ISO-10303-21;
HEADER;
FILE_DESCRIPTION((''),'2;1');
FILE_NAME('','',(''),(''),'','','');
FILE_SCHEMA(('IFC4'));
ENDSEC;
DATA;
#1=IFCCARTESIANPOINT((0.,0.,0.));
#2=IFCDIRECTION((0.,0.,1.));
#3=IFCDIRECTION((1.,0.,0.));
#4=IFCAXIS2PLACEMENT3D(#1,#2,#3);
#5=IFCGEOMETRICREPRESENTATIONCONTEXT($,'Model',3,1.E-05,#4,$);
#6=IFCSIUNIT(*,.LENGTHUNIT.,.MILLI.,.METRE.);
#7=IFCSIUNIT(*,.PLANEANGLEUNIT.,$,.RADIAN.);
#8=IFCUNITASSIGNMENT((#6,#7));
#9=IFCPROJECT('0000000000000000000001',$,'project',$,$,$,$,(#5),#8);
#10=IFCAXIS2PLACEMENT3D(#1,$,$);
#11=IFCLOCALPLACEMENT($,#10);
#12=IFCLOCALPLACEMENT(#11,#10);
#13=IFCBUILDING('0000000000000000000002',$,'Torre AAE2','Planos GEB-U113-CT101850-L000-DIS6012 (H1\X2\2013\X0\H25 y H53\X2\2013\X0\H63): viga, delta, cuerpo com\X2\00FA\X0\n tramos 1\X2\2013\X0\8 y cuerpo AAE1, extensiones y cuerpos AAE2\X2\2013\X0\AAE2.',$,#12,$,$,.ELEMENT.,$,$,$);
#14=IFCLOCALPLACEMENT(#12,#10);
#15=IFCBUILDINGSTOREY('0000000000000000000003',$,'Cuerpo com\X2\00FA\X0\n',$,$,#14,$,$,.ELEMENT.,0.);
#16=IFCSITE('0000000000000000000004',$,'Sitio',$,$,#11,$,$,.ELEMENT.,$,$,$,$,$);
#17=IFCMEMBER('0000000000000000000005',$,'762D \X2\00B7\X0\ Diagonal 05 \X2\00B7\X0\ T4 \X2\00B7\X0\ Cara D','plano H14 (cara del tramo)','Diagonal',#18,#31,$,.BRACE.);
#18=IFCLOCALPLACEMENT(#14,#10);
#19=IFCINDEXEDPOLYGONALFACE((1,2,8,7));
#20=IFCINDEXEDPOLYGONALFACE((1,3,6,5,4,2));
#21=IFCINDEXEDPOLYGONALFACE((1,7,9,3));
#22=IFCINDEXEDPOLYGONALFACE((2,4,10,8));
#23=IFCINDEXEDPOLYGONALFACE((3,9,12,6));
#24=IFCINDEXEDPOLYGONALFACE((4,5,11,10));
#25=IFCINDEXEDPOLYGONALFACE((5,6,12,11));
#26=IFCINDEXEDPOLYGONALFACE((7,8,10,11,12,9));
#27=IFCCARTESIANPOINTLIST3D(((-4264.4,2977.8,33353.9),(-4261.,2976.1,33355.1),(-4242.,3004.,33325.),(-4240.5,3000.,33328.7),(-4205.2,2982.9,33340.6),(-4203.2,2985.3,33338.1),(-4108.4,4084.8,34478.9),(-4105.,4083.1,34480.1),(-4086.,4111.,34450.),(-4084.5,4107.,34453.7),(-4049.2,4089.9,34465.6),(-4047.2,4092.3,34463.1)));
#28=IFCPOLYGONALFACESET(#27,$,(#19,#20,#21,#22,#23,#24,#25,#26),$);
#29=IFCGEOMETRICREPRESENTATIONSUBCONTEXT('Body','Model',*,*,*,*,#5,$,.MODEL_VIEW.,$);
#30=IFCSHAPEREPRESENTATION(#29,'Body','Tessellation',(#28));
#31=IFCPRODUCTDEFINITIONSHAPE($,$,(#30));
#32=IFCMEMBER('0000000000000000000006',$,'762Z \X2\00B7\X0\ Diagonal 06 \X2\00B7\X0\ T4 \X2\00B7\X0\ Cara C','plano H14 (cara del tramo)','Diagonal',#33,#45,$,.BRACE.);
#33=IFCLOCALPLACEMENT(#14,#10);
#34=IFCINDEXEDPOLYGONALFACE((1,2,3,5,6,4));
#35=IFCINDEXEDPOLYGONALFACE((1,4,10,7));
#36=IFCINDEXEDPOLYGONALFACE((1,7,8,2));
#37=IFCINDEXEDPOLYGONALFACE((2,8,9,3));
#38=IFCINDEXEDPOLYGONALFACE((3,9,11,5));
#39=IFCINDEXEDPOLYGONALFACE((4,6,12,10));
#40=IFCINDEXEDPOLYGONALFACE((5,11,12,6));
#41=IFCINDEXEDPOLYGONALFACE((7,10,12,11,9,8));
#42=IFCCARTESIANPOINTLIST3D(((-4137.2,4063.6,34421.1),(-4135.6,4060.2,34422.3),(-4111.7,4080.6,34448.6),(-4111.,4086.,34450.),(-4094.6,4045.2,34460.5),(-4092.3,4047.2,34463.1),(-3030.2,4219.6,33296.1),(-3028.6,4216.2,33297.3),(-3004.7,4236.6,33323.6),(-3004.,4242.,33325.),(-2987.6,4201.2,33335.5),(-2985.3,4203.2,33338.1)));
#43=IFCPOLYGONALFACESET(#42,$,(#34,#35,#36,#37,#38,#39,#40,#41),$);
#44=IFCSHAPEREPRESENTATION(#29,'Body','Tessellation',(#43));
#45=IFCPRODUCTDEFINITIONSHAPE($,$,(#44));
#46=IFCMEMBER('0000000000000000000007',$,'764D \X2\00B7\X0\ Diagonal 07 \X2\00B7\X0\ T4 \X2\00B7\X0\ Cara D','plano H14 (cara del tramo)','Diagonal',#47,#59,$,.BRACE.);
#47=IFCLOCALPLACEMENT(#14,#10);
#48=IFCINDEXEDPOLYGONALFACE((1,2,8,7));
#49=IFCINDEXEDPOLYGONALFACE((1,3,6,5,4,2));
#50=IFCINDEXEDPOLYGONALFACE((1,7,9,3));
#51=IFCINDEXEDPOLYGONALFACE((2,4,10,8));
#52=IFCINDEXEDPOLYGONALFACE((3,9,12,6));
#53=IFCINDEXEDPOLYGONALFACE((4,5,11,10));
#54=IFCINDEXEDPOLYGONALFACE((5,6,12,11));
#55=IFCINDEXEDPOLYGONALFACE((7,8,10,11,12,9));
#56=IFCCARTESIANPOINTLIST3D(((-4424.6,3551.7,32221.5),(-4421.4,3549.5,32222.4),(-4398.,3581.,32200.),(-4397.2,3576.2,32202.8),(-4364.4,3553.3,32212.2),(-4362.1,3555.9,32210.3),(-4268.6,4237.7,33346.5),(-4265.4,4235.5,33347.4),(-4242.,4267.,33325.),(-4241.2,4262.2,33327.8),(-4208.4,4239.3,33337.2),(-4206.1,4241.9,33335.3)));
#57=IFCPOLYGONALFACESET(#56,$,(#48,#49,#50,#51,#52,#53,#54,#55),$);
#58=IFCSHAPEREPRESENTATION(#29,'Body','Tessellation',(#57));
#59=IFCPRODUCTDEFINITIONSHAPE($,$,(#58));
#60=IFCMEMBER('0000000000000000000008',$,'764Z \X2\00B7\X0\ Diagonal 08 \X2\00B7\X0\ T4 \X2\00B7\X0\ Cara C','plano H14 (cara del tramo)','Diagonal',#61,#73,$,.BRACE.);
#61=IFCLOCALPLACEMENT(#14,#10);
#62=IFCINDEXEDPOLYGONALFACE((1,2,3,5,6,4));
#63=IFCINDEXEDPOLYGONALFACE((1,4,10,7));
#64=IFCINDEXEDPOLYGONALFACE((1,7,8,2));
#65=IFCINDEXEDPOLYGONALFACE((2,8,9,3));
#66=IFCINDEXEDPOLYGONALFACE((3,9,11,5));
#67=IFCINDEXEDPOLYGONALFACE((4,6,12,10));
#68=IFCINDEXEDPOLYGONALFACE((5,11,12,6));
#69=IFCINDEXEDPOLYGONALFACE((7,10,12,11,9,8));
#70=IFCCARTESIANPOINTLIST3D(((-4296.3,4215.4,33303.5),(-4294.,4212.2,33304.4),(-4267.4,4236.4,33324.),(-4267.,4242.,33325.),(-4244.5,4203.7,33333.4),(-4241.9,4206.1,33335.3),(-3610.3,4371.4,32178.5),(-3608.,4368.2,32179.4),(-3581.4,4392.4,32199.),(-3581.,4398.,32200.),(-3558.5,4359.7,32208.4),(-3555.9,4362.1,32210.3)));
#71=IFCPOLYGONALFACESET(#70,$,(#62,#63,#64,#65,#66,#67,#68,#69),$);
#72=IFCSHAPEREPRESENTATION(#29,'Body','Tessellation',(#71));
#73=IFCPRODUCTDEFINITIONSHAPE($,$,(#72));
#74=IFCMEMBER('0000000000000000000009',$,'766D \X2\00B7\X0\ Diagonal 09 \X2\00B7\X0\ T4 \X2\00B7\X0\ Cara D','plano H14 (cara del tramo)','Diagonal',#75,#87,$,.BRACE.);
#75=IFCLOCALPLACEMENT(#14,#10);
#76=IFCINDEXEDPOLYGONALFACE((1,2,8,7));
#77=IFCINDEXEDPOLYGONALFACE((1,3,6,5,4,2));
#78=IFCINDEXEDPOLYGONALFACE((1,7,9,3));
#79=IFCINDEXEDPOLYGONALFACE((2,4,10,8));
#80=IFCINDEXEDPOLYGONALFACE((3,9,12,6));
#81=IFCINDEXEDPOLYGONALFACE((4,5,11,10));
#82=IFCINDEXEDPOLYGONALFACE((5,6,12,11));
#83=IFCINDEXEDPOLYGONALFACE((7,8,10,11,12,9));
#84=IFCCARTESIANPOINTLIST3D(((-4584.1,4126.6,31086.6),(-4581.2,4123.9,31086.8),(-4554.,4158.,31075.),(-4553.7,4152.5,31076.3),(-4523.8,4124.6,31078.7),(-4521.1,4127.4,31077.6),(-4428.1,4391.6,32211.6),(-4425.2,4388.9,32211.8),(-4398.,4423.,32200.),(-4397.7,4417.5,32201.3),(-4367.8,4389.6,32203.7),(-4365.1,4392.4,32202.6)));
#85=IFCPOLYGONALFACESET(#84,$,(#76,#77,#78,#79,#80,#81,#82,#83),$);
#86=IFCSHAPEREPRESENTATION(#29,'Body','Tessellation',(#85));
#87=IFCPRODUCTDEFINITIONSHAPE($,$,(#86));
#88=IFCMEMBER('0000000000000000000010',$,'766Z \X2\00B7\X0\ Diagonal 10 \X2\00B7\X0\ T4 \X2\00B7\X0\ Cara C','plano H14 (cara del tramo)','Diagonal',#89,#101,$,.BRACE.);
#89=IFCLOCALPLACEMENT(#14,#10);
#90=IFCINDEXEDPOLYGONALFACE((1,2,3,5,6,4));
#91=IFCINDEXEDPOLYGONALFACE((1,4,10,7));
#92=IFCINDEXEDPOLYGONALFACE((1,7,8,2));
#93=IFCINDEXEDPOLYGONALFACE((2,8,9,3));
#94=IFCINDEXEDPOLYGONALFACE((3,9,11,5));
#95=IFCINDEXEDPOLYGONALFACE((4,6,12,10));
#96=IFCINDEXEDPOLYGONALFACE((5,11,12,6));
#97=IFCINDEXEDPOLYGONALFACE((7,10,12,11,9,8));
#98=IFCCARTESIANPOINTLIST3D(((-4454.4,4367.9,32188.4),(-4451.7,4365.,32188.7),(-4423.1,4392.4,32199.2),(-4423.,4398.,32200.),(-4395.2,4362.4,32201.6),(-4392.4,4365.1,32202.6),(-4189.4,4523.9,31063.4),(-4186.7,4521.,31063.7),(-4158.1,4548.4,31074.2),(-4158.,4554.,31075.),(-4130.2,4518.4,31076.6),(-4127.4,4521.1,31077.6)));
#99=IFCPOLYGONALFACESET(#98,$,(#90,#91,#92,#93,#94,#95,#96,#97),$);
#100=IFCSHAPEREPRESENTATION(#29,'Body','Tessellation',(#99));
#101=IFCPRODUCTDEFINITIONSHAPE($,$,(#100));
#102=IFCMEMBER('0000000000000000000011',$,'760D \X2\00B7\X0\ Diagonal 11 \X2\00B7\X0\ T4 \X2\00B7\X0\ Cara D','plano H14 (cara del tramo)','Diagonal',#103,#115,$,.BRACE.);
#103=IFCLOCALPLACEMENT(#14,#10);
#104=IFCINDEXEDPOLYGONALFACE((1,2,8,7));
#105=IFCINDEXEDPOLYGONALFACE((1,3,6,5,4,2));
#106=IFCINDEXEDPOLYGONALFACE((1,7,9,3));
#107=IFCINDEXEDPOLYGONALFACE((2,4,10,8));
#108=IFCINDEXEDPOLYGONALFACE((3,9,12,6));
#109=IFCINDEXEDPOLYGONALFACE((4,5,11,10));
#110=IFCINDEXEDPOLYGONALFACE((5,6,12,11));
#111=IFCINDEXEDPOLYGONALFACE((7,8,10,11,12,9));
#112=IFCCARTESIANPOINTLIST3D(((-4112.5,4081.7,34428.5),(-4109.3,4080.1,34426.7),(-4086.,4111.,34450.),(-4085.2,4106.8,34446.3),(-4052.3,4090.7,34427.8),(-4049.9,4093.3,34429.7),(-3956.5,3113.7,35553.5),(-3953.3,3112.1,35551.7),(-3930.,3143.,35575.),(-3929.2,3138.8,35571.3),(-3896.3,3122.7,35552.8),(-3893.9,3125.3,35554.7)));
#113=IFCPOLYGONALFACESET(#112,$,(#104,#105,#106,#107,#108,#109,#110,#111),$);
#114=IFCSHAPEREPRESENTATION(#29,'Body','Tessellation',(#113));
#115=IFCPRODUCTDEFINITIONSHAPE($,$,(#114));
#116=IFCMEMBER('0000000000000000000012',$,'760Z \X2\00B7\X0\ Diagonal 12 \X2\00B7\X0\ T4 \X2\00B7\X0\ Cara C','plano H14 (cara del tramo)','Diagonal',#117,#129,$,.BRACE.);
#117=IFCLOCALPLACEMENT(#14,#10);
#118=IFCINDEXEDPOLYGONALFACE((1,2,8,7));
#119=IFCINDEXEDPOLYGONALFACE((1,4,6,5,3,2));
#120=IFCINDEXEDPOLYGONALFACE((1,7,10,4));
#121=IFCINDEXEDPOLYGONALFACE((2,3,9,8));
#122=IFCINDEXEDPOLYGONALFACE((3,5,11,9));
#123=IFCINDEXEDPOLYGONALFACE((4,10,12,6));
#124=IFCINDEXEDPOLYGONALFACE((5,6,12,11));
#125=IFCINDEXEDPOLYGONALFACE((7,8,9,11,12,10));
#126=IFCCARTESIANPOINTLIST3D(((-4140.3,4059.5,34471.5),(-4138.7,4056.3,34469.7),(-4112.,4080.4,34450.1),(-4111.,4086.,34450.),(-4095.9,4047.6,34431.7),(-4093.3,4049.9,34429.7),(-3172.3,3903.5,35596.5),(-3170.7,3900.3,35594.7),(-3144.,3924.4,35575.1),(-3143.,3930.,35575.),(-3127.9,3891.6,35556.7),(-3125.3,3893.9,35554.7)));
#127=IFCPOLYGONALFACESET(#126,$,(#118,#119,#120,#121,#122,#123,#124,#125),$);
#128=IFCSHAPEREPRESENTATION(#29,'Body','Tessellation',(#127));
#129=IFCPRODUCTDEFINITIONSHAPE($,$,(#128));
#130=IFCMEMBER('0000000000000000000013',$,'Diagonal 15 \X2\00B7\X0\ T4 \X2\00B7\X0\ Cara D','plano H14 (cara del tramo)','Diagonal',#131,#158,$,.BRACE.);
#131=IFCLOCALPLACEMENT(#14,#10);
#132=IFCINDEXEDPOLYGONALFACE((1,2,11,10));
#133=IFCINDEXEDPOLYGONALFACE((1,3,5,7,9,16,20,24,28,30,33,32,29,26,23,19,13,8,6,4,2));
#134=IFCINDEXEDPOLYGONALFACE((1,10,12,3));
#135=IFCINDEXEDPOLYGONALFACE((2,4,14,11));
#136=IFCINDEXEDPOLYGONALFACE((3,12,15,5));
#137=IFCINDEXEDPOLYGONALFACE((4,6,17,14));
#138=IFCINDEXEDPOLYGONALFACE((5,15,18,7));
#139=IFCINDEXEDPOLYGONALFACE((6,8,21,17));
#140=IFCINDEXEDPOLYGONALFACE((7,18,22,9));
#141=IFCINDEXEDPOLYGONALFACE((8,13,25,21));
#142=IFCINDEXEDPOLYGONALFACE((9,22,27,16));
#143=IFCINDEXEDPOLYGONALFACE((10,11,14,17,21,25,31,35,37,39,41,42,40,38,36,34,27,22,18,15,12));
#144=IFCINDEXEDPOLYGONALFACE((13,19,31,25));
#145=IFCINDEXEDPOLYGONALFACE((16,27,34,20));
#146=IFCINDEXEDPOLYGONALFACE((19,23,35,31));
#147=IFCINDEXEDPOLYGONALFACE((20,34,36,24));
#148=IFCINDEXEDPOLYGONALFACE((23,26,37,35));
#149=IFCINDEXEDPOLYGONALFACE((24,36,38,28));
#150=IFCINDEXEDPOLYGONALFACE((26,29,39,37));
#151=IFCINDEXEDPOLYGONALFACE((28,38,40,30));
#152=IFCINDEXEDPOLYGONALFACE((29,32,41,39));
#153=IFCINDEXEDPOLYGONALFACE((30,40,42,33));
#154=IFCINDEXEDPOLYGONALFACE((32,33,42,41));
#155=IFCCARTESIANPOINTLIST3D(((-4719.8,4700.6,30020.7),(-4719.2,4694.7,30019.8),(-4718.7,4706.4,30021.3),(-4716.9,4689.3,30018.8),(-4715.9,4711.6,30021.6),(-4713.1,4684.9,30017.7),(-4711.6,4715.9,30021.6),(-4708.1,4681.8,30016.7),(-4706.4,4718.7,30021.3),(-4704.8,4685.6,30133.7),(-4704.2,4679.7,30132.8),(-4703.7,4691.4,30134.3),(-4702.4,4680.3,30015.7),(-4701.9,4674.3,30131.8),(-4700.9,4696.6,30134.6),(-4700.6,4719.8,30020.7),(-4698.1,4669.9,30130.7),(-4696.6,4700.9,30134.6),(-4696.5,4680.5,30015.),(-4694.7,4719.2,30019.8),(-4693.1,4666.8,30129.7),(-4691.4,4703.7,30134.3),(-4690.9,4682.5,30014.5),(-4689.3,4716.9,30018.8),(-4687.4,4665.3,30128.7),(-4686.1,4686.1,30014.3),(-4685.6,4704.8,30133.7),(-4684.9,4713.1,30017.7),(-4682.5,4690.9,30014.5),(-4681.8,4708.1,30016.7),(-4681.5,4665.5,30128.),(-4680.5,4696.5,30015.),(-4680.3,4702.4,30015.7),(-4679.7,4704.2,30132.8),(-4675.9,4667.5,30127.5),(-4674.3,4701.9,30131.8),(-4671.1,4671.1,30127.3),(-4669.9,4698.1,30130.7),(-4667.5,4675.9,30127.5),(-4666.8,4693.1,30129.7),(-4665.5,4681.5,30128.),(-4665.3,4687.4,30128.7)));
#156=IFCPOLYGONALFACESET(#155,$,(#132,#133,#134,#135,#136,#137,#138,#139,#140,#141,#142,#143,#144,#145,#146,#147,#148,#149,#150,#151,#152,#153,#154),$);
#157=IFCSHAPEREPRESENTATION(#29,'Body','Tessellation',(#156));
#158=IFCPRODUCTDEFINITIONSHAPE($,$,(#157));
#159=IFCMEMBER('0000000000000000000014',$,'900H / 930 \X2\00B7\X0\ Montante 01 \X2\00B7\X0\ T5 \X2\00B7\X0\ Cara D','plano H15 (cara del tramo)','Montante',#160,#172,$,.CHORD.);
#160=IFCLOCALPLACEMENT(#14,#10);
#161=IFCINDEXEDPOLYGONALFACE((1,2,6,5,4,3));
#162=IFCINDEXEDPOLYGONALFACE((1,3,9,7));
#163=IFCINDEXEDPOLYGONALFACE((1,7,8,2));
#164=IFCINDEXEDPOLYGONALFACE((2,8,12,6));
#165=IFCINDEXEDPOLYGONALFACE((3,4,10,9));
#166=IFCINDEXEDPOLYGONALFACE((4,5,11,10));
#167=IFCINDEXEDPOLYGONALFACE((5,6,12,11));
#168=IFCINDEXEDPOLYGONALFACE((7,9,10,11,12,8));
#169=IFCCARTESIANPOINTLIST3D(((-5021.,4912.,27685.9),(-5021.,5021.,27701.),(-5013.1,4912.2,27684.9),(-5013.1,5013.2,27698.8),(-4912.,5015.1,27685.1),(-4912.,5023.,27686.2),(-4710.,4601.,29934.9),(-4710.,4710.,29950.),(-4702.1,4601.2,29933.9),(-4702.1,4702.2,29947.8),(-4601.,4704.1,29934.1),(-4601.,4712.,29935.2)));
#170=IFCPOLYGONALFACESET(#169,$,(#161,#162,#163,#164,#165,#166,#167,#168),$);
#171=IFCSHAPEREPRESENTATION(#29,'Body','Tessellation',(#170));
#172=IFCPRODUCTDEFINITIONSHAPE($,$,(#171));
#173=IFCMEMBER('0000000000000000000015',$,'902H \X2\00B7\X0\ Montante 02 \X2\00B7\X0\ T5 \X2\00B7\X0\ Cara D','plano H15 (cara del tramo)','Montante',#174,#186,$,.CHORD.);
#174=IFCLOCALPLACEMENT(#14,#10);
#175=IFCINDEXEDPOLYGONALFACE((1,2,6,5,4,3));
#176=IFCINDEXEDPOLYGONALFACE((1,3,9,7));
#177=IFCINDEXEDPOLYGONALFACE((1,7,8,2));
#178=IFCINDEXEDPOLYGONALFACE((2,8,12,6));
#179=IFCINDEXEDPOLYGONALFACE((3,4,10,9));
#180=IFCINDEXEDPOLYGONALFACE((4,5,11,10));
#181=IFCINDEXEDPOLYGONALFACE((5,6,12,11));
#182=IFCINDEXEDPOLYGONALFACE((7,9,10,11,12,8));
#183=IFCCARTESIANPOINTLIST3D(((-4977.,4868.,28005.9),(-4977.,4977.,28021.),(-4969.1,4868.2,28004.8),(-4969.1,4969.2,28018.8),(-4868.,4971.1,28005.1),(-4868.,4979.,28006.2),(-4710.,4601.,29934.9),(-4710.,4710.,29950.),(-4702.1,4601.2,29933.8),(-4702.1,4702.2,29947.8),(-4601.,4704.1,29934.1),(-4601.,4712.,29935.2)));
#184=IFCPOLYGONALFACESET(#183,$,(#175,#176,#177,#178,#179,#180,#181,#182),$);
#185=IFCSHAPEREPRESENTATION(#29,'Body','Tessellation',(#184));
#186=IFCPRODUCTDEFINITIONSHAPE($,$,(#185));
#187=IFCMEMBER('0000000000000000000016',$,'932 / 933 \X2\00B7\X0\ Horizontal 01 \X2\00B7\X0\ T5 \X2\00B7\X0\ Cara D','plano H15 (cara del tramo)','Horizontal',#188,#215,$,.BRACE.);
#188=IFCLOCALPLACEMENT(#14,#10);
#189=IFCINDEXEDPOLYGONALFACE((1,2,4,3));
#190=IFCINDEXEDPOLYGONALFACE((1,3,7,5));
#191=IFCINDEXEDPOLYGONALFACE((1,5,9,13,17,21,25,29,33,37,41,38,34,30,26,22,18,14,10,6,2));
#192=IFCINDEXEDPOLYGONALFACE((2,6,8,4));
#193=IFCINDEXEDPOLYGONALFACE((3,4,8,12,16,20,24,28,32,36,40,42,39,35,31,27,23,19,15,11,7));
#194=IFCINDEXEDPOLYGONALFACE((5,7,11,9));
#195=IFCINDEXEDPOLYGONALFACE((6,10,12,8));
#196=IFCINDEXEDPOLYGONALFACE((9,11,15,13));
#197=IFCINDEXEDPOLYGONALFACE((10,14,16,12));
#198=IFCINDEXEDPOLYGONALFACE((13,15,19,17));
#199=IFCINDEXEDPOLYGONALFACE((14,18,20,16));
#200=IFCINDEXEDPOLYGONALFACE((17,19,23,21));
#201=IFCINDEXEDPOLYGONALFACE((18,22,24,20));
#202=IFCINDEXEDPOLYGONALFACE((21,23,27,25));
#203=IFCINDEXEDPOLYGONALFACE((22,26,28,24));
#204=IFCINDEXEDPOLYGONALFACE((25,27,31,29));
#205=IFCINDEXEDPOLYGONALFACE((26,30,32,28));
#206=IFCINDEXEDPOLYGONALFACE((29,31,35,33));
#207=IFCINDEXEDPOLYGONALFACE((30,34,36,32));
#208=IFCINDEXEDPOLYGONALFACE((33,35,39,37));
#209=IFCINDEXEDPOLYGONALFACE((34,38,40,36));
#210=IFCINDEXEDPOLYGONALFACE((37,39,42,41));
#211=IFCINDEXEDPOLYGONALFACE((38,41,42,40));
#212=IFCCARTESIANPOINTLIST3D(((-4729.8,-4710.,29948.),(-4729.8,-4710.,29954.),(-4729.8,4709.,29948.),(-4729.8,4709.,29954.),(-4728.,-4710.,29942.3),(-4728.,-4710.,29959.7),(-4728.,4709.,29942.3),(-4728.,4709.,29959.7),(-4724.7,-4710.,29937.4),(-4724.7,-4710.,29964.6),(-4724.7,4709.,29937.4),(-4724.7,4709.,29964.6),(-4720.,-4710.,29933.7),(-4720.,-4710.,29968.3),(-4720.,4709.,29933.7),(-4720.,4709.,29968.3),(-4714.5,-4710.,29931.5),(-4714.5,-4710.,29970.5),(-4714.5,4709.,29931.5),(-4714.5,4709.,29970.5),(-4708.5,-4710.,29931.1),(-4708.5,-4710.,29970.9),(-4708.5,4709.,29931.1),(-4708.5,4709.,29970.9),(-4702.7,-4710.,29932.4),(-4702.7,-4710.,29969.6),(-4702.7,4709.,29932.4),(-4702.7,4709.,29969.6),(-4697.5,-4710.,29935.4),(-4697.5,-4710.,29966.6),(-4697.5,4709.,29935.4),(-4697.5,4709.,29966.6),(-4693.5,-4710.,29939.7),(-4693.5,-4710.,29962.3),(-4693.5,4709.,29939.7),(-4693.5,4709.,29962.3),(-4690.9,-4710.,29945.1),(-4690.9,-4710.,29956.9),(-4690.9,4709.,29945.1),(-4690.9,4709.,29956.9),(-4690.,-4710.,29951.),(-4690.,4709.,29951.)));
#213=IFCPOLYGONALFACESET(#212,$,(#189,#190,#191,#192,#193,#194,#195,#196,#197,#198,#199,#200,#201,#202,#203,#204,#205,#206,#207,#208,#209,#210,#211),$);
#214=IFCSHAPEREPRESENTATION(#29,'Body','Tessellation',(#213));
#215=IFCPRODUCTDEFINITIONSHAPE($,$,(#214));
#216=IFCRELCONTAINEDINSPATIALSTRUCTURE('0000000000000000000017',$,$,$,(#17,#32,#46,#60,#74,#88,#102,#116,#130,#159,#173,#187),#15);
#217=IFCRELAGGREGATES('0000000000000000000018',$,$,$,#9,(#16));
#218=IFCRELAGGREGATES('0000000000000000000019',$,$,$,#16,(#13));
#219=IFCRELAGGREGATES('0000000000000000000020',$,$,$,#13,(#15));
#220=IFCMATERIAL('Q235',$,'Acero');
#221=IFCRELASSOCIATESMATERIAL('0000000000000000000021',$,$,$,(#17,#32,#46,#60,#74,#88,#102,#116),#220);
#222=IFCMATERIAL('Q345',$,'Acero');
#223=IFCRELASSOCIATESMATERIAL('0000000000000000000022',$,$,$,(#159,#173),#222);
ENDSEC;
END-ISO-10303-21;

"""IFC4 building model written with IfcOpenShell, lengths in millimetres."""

from ifc_helpers import new_model, si_unit, frame, frame_2d, origin, origin_with_axes, place, context, subcontext, project, spatial, circle, l_section, extrude, material, element, save


model = new_model("IFC4")

# Units and contexts
model_context = context("Model", 3, precision=1e-05, world=origin_with_axes())
body_context = subcontext(model_context, "Body", "Model", "MODEL_VIEW")
ifc_project = project(units=[si_unit("LENGTHUNIT", "METRE", prefix="MILLI"), si_unit("PLANEANGLEUNIT", "RADIAN")], contexts=[model_context])

# Site, building, storey
site_placement = place(None, origin())
site = spatial("IfcSite", under=ifc_project, at=site_placement, Name="Sitio", CompositionType="ELEMENT")
building_placement = place(site_placement, origin())
building = spatial("IfcBuilding", under=site, at=building_placement, Name="Torre AAE2", Description="Planos GEB-U113-CT101850-L000-DIS6012 (H1–H25 y H53–H63): viga, delta, cuerpo común tramos 1–8 y cuerpo AAE1, extensiones y cuerpos AAE2–AAE2.", CompositionType="ELEMENT")
storey_placement = place(building_placement, origin())
storey = spatial("IfcBuildingStorey", under=building, at=storey_placement, Name="Cuerpo común", CompositionType="ELEMENT", Elevation=0.0)

# Members
ifc_material_1 = material(Name="Q235", Category="Acero")
for number, where, z_axis, x_axis, name in (
    (1, (-4086.0, 4111.0, 34450.0), (-0.09836, -0.69798, -0.70933), (0.861689, -0.416299, 0.290151), "762D · Diagonal 05 · T4 · Cara D"),
    (2, (-4111.0, 4086.0, 34450.0), (0.69798, 0.09836, -0.70933), (0.416299, -0.861689, 0.290151), "762Z · Diagonal 06 · T4 · Cara C"),
):
    element("IfcMember", number, at=place(storey_placement, frame(where, z_axis=z_axis, x_axis=x_axis)), inside=storey, material=ifc_material_1, Name=name, Description="plano H14 (cara del tramo)", ObjectType="Diagonal", PredefinedType="BRACE", context=body_context, shape_type="SweptSolid", body=[
        extrude(l_section(Depth=45.0, Width=45.0, Thickness=4.0, at=frame_2d((22.5, 22.5))), None, (0.0, 0.0, 1.0), 1586.0),
    ])
for number, where, z_axis, x_axis, name in (
    (3, (-4242.0, 4267.0, 33325.0), (-0.117571, -0.51701, -0.847867), (0.798444, -0.556878, 0.228854), "764D · Diagonal 07 · T4 · Cara D"),
    (4, (-4267.0, 4242.0, 33325.0), (0.51701, 0.117571, -0.847867), (0.556878, -0.798444, 0.228854), "764Z · Diagonal 08 · T4 · Cara C"),
):
    element("IfcMember", number, at=place(storey_placement, frame(where, z_axis=z_axis, x_axis=x_axis)), inside=storey, material=ifc_material_1, Name=name, Description="plano H14 (cara del tramo)", ObjectType="Diagonal", PredefinedType="BRACE", context=body_context, shape_type="SweptSolid", body=[
        extrude(l_section(Depth=45.0, Width=45.0, Thickness=4.0, at=frame_2d((22.5, 22.5))), None, (0.0, 0.0, 1.0), 1326.9),
    ])
for number, where, z_axis, x_axis, name in (
    (5, (-4398.0, 4423.0, 32200.0), (-0.13376, -0.22722, -0.964614), (0.73137, -0.679455, 0.058633), "766D · Diagonal 09 · T4 · Cara D"),
    (6, (-4423.0, 4398.0, 32200.0), (0.22722, 0.13376, -0.964614), (0.679455, -0.73137, 0.058633), "766Z · Diagonal 10 · T4 · Cara C"),
):
    element("IfcMember", number, at=place(storey_placement, frame(where, z_axis=z_axis, x_axis=x_axis)), inside=storey, material=ifc_material_1, Name=name, Description="plano H14 (cara del tramo)", ObjectType="Diagonal", PredefinedType="BRACE", context=body_context, shape_type="SweptSolid", body=[
        extrude(l_section(Depth=45.0, Width=45.0, Thickness=4.0, at=frame_2d((22.5, 22.5))), None, (0.0, 0.0, 1.0), 1166.3),
    ])
for number, where, z_axis, x_axis, name in (
    (7, (-3930.0, 3143.0, 35575.0), (-0.104536, 0.648659, -0.753866), (0.801211, -0.394141, -0.450238), "760D · Diagonal 11 · T4 · Cara D"),
    (8, (-3143.0, 3930.0, 35575.0), (-0.648659, 0.104536, -0.753866), (0.394141, -0.801211, -0.450238), "760Z · Diagonal 12 · T4 · Cara C"),
):
    element("IfcMember", number, at=place(storey_placement, frame(where, z_axis=z_axis, x_axis=x_axis)), inside=storey, material=ifc_material_1, Name=name, Description="plano H14 (cara del tramo)", ObjectType="Diagonal", PredefinedType="BRACE", context=body_context, shape_type="SweptSolid", body=[
        extrude(l_section(Depth=45.0, Width=45.0, Thickness=4.0, at=frame_2d((22.5, 22.5))), None, (0.0, 0.0, 1.0), 1492.3),
    ])
member_1_placement = place(storey_placement, frame((-4685.0, 4685.0, 30131.0), z_axis=(-0.130464, 0.130464, -0.982832), x_axis=(0.694967, -0.694967, -0.184504)))
element("IfcMember", 9, at=member_1_placement, inside=storey, Name="Diagonal 15 · T4 · Cara D", Description="plano H14 (cara del tramo)", ObjectType="Diagonal", PredefinedType="BRACE", context=body_context, shape_type="SweptSolid", body=[
    extrude(circle(Radius=20.0), None, (0.0, 0.0, 1.0), 115.0),
])
ifc_material_2 = material(Name="Q345", Category="Acero")
member_2_placement = place(storey_placement, frame((-4710.0, 4710.0, 29950.0), z_axis=(-0.135713, 0.135713, -0.981409), x_axis=(0.990748, 0.01859, -0.134434)))
element("IfcMember", 10, at=member_2_placement, inside=storey, material=ifc_material_2, Name="900H / 930 · Montante 01 · T5 · Cara D", Description="plano H15 (cara del tramo)", ObjectType="Montante", PredefinedType="CHORD", context=body_context, shape_type="SweptSolid", body=[
    extrude(l_section(Depth=110.0, Width=110.0, Thickness=8.0, at=frame_2d((55.0, 55.0))), None, (0.0, 0.0, 1.0), 2291.6),
])
member_3_placement = place(storey_placement, frame((-4710.0, 4710.0, 29950.0), z_axis=(-0.135836, 0.135836, -0.981375), x_axis=(0.990731, 0.018624, -0.134553)))
element("IfcMember", 11, at=member_3_placement, inside=storey, material=ifc_material_2, Name="902H · Montante 02 · T5 · Cara D", Description="plano H15 (cara del tramo)", ObjectType="Montante", PredefinedType="CHORD", context=body_context, shape_type="SweptSolid", body=[
    extrude(l_section(Depth=110.0, Width=110.0, Thickness=8.0, at=frame_2d((55.0, 55.0))), None, (0.0, 0.0, 1.0), 1965.6),
])
member_4_placement = place(storey_placement, frame((-4710.0, 4709.0, 29951.0), z_axis=(0.0, -1.0, 0.0), x_axis=(1.0, 0.0, 0.0)))
element("IfcMember", 12, at=member_4_placement, inside=storey, Name="932 / 933 · Horizontal 01 · T5 · Cara D", Description="plano H15 (cara del tramo)", ObjectType="Horizontal", PredefinedType="BRACE", context=body_context, shape_type="SweptSolid", body=[
    extrude(circle(Radius=20.0), None, (0.0, 0.0, 1.0), 9419.0),
])

save(model, "model.ifc")
